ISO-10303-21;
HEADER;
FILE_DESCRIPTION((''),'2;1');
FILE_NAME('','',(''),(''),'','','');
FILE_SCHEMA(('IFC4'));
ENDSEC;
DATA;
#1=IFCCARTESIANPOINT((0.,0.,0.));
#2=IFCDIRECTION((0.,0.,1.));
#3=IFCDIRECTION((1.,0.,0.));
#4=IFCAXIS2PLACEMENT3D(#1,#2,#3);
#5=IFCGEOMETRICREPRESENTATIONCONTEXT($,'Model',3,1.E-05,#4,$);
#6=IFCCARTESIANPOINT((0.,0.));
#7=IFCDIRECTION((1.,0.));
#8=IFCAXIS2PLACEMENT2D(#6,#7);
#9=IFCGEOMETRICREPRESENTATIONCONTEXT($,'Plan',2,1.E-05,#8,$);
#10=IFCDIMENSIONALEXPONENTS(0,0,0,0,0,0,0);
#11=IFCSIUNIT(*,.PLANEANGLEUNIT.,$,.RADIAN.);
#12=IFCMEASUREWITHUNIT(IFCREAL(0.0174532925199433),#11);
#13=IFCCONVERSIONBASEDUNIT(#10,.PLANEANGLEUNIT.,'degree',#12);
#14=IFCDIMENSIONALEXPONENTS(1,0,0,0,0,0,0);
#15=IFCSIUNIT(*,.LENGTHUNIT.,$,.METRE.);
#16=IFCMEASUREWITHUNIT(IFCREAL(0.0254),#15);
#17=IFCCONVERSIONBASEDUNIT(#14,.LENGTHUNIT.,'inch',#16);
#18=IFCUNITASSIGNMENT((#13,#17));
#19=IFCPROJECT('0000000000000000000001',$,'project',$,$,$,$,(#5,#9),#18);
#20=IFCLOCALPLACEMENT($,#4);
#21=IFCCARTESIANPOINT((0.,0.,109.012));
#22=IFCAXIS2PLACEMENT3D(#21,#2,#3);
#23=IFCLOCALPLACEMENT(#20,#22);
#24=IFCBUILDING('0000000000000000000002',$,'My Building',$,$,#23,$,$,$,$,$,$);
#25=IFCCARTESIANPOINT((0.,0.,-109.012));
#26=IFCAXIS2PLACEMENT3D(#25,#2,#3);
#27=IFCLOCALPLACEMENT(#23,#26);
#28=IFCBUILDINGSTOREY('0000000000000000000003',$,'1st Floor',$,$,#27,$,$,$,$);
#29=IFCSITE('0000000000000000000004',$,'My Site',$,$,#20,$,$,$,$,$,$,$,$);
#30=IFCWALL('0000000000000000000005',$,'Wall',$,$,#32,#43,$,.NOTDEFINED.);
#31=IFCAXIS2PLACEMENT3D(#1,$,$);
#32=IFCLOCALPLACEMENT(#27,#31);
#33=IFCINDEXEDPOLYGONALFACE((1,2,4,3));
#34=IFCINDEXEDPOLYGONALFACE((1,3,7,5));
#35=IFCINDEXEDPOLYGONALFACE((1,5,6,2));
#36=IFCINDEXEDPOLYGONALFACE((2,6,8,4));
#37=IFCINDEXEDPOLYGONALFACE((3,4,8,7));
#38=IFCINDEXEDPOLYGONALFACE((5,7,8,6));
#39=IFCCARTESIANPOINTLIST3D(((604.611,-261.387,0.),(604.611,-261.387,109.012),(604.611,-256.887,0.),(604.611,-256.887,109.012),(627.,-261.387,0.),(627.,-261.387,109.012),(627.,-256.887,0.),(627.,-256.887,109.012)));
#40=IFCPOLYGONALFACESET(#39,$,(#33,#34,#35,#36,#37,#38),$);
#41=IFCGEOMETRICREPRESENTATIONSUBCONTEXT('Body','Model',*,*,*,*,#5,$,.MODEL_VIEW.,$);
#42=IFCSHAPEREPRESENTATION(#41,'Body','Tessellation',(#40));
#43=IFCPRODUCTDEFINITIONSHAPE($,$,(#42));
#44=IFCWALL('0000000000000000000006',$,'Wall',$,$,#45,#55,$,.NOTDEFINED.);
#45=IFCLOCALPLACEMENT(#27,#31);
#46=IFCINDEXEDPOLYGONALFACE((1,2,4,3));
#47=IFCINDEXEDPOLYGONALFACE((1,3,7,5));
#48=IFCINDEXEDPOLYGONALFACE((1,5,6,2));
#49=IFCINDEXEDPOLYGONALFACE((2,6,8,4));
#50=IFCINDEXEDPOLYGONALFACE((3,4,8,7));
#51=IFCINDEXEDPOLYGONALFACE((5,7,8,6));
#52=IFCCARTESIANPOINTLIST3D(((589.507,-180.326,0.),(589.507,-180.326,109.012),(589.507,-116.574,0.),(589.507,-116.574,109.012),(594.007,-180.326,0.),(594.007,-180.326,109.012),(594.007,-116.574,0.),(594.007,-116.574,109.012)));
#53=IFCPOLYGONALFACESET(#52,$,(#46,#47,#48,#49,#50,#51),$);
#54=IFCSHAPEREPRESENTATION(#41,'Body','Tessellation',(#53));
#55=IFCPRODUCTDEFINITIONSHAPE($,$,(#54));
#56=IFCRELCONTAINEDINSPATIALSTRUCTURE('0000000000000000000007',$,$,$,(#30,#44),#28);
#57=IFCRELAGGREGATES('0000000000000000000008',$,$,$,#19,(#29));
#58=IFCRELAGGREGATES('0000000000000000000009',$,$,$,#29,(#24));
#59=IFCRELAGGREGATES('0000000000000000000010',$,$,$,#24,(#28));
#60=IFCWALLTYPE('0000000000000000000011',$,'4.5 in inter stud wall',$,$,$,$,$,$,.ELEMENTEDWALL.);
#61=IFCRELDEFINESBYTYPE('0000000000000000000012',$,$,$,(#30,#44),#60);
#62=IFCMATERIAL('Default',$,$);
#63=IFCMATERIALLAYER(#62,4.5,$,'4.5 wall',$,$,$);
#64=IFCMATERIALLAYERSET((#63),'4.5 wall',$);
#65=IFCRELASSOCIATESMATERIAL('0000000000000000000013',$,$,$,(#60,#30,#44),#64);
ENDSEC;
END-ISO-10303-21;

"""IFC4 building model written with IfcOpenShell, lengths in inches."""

from ifc_helpers import new_model, entity, si_unit, converted_unit, frame, origin_with_axes, origin_2d_with_axis, place, context, subcontext, project, spatial, indexed_curve, outline, extrude, material, layer, layer_set, layer_usage, type_object, element, save


model = new_model("IFC4")

# Units and contexts
model_context = context("Model", 3, precision=1e-05, world=origin_with_axes())
plan_context = context("Plan", 2, precision=1e-05, world=origin_2d_with_axis())
body_context = subcontext(model_context, "Body", "Model", "MODEL_VIEW")
ifc_project = project(units=[converted_unit("PLANEANGLEUNIT", "degree", entity("IfcReal", 0.0174532925199433), si_unit("PLANEANGLEUNIT", "RADIAN"), dimensions=[0, 0, 0, 0, 0, 0, 0]), converted_unit("LENGTHUNIT", "inch", entity("IfcReal", 0.0254), si_unit("LENGTHUNIT", "METRE"), dimensions=[1, 0, 0, 0, 0, 0, 0])], contexts=[model_context, plan_context])

# Site, building, storey
site_placement = place(None, origin_with_axes())
site = spatial("IfcSite", under=ifc_project, at=site_placement, Name="My Site")
building_placement = place(site_placement, frame((0.0, 0.0, 109.012), z_axis=(0.0, 0.0, 1.0), x_axis=(1.0, 0.0, 0.0)))
building = spatial("IfcBuilding", under=site, at=building_placement, Name="My Building")
storey_placement = place(building_placement, frame((0.0, 0.0, -109.012), z_axis=(0.0, 0.0, 1.0), x_axis=(1.0, 0.0, 0.0)))
storey = spatial("IfcBuildingStorey", under=building, at=storey_placement, Name="1st Floor")

# Shared definitions
ifc_material = material(Name="Default")

# Walls
ifc_layer_1 = layer(ifc_material, 4.5, Name="4.5 wall")
ifc_layer_set_1 = layer_set([ifc_layer_1], Name="4.5 wall")
wall_type_1 = type_object("IfcWallType", Name="4.5 in inter stud wall", PredefinedType="ELEMENTEDWALL", material=ifc_layer_set_1)
ifc_layer_usage_1 = layer_usage(ifc_layer_set_1, "AXIS2", "POSITIVE", 0.0)
wall_1_placement = place(storey_placement, frame((604.611, -261.387, 0.0), z_axis=(0.0, 0.0, 1.0), x_axis=(1.0, 0.0, 0.0)))
element("IfcWall", 1, at=wall_1_placement, inside=storey, type_object=wall_type_1, material=ifc_layer_usage_1, Name="Wall", PredefinedType="NOTDEFINED", context=body_context, shape_type="SweptSolid", body=[
    extrude(outline(indexed_curve([(0.0, 0.0), (0.0, 4.5), (22.389, 4.5), (22.389, 0.0), (0.0, 0.0)], self_intersect=False)), origin_with_axes(), (0.0, 0.0, 1.0), 109.012),
])
ifc_layer_usage_2 = layer_usage(ifc_layer_set_1, "AXIS2", "POSITIVE", 0.0)
wall_2_placement = place(storey_placement, frame((589.507, -116.574, 0.0), z_axis=(0.0, 0.0, 1.0), x_axis=(-0.000001, -1.0, 0.0)))
element("IfcWall", 2, at=wall_2_placement, inside=storey, type_object=wall_type_1, material=ifc_layer_usage_2, Name="Wall", PredefinedType="NOTDEFINED", context=body_context, shape_type="SweptSolid", body=[
    extrude(outline(indexed_curve([(0.0, 0.0), (0.0, 4.5), (63.753, 4.5), (63.753, 0.0), (0.0, 0.0)], self_intersect=False)), origin_with_axes(), (0.0, 0.0, 1.0), 109.012),
])

save(model, "model.ifc")
